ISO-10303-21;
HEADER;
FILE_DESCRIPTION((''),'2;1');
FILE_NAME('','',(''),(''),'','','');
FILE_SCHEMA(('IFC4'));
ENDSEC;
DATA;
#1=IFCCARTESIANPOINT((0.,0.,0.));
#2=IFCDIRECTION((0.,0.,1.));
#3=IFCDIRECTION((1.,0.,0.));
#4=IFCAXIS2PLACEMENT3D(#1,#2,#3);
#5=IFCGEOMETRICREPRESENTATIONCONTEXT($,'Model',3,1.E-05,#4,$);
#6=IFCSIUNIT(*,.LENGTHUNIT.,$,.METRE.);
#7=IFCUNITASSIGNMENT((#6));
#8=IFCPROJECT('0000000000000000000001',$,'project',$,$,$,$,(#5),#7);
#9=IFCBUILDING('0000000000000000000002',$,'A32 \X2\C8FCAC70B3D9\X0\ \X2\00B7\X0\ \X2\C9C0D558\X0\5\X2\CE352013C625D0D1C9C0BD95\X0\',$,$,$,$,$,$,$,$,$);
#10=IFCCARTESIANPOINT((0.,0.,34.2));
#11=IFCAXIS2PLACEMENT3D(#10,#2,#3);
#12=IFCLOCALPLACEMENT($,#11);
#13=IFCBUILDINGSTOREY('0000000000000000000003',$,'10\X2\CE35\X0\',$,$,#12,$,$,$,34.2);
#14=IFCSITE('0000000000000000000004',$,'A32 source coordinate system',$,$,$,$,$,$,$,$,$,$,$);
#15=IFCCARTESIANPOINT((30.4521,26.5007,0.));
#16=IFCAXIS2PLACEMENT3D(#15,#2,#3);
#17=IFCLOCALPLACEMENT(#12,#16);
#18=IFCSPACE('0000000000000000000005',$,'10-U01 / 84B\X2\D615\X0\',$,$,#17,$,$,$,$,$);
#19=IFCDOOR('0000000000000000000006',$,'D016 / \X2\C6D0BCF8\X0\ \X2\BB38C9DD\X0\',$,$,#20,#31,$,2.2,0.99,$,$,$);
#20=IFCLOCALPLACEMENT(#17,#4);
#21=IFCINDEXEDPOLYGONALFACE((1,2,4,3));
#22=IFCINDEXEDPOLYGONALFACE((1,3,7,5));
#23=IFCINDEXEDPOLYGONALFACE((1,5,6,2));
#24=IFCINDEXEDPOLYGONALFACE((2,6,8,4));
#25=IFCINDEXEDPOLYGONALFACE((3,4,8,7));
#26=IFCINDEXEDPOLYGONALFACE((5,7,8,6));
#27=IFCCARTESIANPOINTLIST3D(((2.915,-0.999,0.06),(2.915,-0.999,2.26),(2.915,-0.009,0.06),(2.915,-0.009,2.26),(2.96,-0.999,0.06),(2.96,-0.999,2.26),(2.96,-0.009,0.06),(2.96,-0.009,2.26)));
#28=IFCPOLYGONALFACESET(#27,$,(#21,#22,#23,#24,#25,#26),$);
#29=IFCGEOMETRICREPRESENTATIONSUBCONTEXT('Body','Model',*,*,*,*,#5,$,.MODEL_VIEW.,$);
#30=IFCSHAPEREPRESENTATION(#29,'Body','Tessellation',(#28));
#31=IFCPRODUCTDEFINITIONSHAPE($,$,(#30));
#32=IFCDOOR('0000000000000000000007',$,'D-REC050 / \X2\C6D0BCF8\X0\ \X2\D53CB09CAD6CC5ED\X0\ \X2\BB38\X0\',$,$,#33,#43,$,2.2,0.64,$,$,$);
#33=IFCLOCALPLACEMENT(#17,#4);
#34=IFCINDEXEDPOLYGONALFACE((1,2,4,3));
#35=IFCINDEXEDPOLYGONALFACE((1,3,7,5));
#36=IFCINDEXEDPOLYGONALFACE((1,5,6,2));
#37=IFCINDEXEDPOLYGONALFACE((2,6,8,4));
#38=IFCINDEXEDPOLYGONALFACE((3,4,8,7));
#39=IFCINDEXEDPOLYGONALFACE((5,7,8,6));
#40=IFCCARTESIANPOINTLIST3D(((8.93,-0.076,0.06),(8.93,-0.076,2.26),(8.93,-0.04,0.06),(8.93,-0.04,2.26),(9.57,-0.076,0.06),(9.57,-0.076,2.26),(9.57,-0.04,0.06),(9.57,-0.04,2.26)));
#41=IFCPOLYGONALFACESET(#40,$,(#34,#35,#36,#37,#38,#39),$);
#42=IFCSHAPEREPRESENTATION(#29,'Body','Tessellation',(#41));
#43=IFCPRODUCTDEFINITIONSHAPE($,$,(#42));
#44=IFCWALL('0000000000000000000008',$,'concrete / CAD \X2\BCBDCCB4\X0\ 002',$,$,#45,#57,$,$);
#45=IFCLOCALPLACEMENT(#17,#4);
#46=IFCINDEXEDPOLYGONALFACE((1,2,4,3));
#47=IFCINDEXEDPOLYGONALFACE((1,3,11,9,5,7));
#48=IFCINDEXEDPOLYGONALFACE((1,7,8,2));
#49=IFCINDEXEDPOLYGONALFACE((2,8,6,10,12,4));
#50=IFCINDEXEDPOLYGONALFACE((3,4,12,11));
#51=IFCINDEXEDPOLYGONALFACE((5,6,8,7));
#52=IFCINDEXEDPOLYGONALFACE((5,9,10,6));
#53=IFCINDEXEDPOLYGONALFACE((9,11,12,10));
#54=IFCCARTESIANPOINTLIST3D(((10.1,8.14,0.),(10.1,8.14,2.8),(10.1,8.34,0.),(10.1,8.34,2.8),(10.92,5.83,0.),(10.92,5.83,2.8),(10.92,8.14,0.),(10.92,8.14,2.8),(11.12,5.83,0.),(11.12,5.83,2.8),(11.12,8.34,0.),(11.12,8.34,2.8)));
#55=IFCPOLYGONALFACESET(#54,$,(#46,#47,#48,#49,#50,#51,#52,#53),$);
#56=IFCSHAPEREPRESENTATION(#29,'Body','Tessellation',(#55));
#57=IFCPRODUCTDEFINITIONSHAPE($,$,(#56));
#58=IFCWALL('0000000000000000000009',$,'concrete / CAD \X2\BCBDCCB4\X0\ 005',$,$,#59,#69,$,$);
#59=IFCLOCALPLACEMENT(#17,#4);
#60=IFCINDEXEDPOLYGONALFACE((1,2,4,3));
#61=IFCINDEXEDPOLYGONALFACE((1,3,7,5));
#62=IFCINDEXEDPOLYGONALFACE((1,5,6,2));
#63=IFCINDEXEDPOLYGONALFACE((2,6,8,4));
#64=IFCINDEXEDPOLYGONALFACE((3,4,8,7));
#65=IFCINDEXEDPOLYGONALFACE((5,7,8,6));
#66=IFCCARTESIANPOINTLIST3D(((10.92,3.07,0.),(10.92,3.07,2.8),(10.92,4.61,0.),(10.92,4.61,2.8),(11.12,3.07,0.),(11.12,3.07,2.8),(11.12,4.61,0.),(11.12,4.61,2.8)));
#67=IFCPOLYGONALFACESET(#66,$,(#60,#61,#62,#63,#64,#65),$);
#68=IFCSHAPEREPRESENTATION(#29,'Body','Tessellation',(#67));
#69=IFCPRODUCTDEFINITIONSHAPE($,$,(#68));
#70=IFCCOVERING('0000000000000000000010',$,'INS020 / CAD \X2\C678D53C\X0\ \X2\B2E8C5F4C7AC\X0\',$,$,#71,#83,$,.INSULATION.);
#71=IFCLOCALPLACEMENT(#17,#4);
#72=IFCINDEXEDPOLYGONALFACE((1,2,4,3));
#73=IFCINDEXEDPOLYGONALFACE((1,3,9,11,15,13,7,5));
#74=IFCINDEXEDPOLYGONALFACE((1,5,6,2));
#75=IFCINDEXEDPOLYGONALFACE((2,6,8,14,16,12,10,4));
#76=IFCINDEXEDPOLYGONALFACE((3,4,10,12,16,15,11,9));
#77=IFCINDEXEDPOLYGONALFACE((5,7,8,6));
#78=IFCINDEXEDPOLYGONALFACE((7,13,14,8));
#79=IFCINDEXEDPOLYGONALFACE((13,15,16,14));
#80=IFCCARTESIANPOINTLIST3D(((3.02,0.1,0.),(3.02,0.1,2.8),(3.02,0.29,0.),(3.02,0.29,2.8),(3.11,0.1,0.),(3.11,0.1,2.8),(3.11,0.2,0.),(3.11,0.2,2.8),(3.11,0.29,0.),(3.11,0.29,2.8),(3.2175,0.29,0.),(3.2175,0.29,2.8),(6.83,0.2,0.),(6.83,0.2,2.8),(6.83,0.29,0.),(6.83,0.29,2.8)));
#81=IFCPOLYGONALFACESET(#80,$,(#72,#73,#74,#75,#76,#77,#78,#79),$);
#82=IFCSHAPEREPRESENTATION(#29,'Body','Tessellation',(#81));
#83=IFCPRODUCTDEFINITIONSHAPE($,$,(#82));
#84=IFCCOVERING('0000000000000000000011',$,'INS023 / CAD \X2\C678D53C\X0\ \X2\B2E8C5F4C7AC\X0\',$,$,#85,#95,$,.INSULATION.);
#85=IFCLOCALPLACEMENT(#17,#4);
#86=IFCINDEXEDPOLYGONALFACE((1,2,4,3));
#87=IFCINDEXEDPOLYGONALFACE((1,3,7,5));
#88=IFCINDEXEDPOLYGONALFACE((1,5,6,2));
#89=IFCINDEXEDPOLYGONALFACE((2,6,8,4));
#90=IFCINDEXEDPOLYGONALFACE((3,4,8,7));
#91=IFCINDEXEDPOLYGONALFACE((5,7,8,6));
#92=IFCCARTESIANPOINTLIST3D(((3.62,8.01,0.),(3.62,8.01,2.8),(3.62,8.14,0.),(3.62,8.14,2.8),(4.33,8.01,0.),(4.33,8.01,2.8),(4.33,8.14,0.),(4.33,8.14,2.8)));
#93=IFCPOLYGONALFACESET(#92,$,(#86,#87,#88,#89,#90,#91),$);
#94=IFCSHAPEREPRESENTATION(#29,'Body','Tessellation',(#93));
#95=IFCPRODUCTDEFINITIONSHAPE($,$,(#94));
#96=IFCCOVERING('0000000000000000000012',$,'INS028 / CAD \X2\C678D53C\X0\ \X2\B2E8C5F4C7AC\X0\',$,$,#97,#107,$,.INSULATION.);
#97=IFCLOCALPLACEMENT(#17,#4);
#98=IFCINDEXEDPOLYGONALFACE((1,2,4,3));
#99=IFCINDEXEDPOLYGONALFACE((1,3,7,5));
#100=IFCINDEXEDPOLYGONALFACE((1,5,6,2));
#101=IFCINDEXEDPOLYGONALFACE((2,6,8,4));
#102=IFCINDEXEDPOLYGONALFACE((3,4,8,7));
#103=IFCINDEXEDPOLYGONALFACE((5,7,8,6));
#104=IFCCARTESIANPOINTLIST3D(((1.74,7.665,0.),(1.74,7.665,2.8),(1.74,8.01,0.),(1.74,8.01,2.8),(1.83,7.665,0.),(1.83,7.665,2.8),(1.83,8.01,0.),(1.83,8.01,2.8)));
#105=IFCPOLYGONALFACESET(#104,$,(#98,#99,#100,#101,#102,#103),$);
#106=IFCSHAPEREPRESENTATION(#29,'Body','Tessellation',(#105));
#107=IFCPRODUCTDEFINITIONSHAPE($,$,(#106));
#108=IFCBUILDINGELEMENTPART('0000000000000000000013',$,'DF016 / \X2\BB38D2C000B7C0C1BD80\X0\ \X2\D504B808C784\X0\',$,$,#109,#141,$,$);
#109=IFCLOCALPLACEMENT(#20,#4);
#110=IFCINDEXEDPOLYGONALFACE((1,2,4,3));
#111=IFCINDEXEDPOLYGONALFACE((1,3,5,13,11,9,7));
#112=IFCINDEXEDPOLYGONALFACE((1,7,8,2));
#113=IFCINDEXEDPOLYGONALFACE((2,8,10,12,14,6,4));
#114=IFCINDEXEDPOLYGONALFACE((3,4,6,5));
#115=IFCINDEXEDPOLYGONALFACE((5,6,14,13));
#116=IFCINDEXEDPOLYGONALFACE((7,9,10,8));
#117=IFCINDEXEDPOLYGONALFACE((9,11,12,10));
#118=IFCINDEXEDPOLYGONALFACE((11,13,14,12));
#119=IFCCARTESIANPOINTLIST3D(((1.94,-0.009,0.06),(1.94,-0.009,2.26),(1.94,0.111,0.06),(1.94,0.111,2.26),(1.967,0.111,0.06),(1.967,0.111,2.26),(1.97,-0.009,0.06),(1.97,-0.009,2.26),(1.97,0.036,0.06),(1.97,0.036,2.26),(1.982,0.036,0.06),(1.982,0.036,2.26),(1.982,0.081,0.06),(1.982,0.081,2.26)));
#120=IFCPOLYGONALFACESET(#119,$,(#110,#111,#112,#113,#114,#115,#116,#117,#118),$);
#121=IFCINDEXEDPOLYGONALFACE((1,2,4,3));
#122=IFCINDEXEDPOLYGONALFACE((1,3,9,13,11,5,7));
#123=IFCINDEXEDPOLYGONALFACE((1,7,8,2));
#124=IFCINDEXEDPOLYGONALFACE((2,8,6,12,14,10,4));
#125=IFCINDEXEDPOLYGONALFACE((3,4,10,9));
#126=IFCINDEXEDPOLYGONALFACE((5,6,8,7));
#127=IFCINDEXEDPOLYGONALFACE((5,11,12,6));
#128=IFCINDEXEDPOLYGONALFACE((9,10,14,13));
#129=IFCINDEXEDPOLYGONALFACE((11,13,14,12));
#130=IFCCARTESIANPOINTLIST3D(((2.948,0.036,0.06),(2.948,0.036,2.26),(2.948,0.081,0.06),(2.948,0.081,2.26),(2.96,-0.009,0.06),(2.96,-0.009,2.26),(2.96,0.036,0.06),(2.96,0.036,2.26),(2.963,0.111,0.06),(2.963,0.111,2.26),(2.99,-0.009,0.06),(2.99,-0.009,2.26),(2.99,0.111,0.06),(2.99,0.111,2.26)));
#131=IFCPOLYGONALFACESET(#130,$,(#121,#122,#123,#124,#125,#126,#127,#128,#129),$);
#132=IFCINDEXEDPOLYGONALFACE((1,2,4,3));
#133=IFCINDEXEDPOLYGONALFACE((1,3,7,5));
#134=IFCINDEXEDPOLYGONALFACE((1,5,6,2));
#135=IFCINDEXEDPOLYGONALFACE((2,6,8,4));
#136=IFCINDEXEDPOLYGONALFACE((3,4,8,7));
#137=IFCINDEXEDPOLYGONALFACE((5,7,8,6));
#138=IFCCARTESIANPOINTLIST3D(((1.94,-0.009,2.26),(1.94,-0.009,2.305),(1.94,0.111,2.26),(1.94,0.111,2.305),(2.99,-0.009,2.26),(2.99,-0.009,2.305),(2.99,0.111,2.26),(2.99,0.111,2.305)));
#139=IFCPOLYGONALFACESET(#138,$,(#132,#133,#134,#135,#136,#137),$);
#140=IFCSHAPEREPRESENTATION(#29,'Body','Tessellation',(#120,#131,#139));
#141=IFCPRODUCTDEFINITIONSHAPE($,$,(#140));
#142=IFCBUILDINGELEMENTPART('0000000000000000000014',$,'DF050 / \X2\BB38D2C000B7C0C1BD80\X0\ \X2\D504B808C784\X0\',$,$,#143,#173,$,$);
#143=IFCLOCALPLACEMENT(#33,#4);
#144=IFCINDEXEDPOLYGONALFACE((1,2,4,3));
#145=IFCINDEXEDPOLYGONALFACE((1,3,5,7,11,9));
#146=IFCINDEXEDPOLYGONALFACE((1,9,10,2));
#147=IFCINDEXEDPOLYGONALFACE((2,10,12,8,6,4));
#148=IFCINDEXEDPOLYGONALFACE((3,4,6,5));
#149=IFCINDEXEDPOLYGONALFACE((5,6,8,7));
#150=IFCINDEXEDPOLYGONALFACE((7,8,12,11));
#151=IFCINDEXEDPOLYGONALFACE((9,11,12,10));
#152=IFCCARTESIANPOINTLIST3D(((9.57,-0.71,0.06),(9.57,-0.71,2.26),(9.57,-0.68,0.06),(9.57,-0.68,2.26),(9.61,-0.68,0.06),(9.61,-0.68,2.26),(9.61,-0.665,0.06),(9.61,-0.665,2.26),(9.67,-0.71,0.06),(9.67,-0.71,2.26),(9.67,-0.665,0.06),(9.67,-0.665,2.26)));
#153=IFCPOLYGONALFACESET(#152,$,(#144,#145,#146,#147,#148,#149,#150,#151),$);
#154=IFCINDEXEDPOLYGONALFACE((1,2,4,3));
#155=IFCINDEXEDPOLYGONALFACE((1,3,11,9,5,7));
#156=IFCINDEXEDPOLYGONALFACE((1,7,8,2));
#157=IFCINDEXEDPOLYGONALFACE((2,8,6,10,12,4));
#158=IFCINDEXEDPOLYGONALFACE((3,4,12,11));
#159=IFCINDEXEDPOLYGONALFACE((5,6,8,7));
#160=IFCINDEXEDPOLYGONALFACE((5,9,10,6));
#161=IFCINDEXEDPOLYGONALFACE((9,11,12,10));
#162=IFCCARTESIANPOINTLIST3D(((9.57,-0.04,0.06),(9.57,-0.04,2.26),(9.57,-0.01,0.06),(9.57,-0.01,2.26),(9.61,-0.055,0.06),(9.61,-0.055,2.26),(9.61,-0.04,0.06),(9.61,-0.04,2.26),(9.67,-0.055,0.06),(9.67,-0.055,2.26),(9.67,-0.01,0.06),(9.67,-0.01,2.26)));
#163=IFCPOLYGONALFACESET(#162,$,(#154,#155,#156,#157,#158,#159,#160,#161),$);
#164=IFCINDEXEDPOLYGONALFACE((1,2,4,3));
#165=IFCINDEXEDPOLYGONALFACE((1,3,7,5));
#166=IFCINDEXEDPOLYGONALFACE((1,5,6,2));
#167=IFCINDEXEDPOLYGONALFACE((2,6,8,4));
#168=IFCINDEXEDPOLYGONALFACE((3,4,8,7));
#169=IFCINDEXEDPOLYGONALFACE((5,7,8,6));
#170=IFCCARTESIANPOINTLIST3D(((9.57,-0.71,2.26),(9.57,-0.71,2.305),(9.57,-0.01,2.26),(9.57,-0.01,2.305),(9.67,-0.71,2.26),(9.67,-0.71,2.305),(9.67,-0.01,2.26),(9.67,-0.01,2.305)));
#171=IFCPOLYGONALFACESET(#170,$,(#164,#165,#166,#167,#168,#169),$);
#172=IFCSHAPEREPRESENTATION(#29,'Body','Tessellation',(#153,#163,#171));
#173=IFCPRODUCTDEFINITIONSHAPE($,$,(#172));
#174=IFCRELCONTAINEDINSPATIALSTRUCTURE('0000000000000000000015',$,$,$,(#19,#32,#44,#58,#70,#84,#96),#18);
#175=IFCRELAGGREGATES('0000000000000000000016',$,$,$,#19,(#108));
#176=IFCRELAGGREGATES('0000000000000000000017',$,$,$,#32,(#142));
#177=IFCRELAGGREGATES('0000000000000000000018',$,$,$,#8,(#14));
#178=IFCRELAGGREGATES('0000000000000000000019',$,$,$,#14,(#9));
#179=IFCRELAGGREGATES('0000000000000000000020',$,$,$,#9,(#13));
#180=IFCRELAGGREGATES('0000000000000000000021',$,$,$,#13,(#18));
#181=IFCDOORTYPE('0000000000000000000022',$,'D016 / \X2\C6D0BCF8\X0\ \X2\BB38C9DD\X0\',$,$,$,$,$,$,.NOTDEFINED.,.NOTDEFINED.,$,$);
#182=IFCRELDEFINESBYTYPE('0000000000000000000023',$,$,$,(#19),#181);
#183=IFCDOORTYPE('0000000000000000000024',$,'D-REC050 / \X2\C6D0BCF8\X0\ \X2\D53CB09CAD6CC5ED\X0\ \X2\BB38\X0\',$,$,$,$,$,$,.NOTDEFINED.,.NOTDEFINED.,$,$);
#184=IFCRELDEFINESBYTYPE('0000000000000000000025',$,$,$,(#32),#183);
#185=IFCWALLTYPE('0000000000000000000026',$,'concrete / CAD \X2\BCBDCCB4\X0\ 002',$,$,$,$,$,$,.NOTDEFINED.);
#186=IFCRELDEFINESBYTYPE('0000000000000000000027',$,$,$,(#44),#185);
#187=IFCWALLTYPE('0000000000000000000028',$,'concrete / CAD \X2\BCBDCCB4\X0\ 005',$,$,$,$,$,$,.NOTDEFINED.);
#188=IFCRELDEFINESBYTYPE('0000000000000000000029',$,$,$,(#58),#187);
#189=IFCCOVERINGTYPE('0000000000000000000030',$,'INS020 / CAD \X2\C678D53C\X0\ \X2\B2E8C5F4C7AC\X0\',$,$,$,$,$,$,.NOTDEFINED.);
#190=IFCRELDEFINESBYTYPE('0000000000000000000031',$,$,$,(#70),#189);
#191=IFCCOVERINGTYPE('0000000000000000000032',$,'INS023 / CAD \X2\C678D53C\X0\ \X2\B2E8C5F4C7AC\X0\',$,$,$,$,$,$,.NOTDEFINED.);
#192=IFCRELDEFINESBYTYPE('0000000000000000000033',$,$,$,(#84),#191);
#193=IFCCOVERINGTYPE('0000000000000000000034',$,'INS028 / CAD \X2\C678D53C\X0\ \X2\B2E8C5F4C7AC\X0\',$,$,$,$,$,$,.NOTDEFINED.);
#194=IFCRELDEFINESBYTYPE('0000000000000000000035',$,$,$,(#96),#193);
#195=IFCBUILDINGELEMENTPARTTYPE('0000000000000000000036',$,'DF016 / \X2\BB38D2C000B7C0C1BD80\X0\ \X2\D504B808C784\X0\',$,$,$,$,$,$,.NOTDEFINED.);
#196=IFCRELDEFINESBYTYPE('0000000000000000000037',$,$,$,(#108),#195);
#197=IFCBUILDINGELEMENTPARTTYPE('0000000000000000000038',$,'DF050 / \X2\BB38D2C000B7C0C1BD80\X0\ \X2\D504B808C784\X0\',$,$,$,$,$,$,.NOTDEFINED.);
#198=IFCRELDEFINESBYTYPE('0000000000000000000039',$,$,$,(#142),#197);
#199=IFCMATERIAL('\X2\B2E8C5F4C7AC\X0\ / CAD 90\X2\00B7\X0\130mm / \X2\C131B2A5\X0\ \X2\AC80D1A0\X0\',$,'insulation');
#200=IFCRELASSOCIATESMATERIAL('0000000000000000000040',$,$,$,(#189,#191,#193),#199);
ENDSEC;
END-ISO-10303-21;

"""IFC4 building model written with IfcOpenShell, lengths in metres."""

from ifc_helpers import new_model, si_unit, frame, origin, origin_with_axes, place, context, subcontext, project, spatial, polyline, outline, extrude, source, transform, mapped, material, type_object, type_shapes, element, aggregate, save


model = new_model("IFC4")

# Units and contexts
model_context = context("Model", 3, precision=1e-05, world=origin_with_axes())
body_context = subcontext(model_context, "Body", "Model", "MODEL_VIEW")
ifc_project = project(units=[si_unit("LENGTHUNIT", "METRE")], contexts=[model_context])

# Site, building, storey, space
storey_placement = place(None, frame((0.0, 0.0, 34.2), z_axis=(0.0, 0.0, 1.0), x_axis=(1.0, 0.0, 0.0)))
space_placement = place(storey_placement, frame((30.4521, 26.5007, 0.0), z_axis=(0.0, 0.0, 1.0), x_axis=(1.0, 0.0, 0.0)))
site = spatial("IfcSite", under=ifc_project, Name="A32 source coordinate system")
building = spatial("IfcBuilding", under=site, Name="A32 주거동 · 지하5층–옥탑지붕")
storey = spatial("IfcBuildingStorey", under=building, at=storey_placement, Name="10층", Elevation=34.2)
space = spatial("IfcSpace", under=storey, at=space_placement, Name="10-U01 / 84B형")

# Doors
door_type_1 = type_object("IfcDoorType", Name="D016 / 원본 문짝", OperationType="NOTDEFINED", PredefinedType="NOTDEFINED")
shared_shape_1 = source(origin(), body_context, "Body", "SweptSolid", [
    extrude(outline(polyline([(2.96, -0.009), (2.96, -0.999), (2.915, -0.999), (2.915, -0.009), (2.96, -0.009)])), frame((0.0, 0.0, 0.06)), (0.0, 0.0, 1.0), 2.2),
])
type_shapes(door_type_1, [shared_shape_1])
door_1_placement = place(space_placement, origin_with_axes())
door_1 = element("IfcDoor", 1, at=door_1_placement, inside=space, type_object=door_type_1, Name="D016 / 원본 문짝", OverallHeight=2.2, OverallWidth=0.99, context=body_context, shape_type="MappedRepresentation", body=[
    mapped(shared_shape_1, transform((0.0, 0.0, 0.0), scale=1.0)),
])
door_type_2 = type_object("IfcDoorType", Name="D-REC050 / 원본 피난구역 문", OperationType="NOTDEFINED", PredefinedType="NOTDEFINED")
shared_shape_2 = source(origin(), body_context, "Body", "SweptSolid", [
    extrude(outline(polyline([(9.57, -0.04), (9.57, -0.076), (8.93, -0.076), (8.93, -0.04), (9.57, -0.04)])), frame((0.0, 0.0, 0.06)), (0.0, 0.0, 1.0), 2.2),
])
type_shapes(door_type_2, [shared_shape_2])
door_2_placement = place(space_placement, origin_with_axes())
door_2 = element("IfcDoor", 2, at=door_2_placement, inside=space, type_object=door_type_2, Name="D-REC050 / 원본 피난구역 문", OverallHeight=2.2, OverallWidth=0.64, context=body_context, shape_type="MappedRepresentation", body=[
    mapped(shared_shape_2, transform((0.0, 0.0, 0.0), scale=1.0)),
])

# Walls
wall_type_1 = type_object("IfcWallType", Name="concrete / CAD 벽체 002", PredefinedType="NOTDEFINED")
shared_shape_3 = source(origin(), body_context, "Body", "SweptSolid", [
    extrude(outline(polyline([(11.12, 5.83), (10.92, 5.83), (10.92, 8.14), (10.1, 8.14), (10.1, 8.34), (11.12, 8.34), (11.12, 5.83)])), origin(), (0.0, 0.0, 1.0), 2.8),
])
type_shapes(wall_type_1, [shared_shape_3])
wall_1_placement = place(space_placement, origin_with_axes())
element("IfcWall", 3, at=wall_1_placement, inside=space, type_object=wall_type_1, Name="concrete / CAD 벽체 002", context=body_context, shape_type="MappedRepresentation", body=[
    mapped(shared_shape_3, transform((0.0, 0.0, 0.0), scale=1.0)),
])
wall_type_2 = type_object("IfcWallType", Name="concrete / CAD 벽체 005", PredefinedType="NOTDEFINED")
shared_shape_4 = source(origin(), body_context, "Body", "SweptSolid", [
    extrude(outline(polyline([(11.12, 3.07), (10.92, 3.07), (10.92, 4.61), (11.12, 4.61), (11.12, 3.07)])), origin(), (0.0, 0.0, 1.0), 2.8),
])
type_shapes(wall_type_2, [shared_shape_4])
wall_2_placement = place(space_placement, origin_with_axes())
element("IfcWall", 4, at=wall_2_placement, inside=space, type_object=wall_type_2, Name="concrete / CAD 벽체 005", context=body_context, shape_type="MappedRepresentation", body=[
    mapped(shared_shape_4, transform((0.0, 0.0, 0.0), scale=1.0)),
])

# Coverings
ifc_material = material(Name="단열재 / CAD 90·130mm / 성능 검토", Category="insulation")
covering_type_1 = type_object("IfcCoveringType", Name="INS020 / CAD 외피 단열재", PredefinedType="NOTDEFINED", material=ifc_material)
shared_shape_5 = source(origin(), body_context, "Body", "SweptSolid", [
    extrude(outline(polyline([(3.11, 0.2), (3.11, 0.1), (3.02, 0.1), (3.02, 0.29), (3.11, 0.29), (3.2175, 0.29), (6.83, 0.29), (6.83, 0.2), (3.11, 0.2)])), origin(), (0.0, 0.0, 1.0), 2.8),
])
type_shapes(covering_type_1, [shared_shape_5])
covering_1_placement = place(space_placement, origin_with_axes())
element("IfcCovering", 5, at=covering_1_placement, inside=space, type_object=covering_type_1, Name="INS020 / CAD 외피 단열재", PredefinedType="INSULATION", context=body_context, shape_type="MappedRepresentation", body=[
    mapped(shared_shape_5, transform((0.0, 0.0, 0.0), scale=1.0)),
])
covering_type_2 = type_object("IfcCoveringType", Name="INS023 / CAD 외피 단열재", PredefinedType="NOTDEFINED", material=ifc_material)
shared_shape_6 = source(origin(), body_context, "Body", "SweptSolid", [
    extrude(outline(polyline([(4.33, 8.01), (3.62, 8.01), (3.62, 8.14), (4.33, 8.14), (4.33, 8.01)])), origin(), (0.0, 0.0, 1.0), 2.8),
])
type_shapes(covering_type_2, [shared_shape_6])
covering_2_placement = place(space_placement, origin_with_axes())
element("IfcCovering", 6, at=covering_2_placement, inside=space, type_object=covering_type_2, Name="INS023 / CAD 외피 단열재", PredefinedType="INSULATION", context=body_context, shape_type="MappedRepresentation", body=[
    mapped(shared_shape_6, transform((0.0, 0.0, 0.0), scale=1.0)),
])
covering_type_3 = type_object("IfcCoveringType", Name="INS028 / CAD 외피 단열재", PredefinedType="NOTDEFINED", material=ifc_material)
shared_shape_7 = source(origin(), body_context, "Body", "SweptSolid", [
    extrude(outline(polyline([(1.74, 8.01), (1.83, 8.01), (1.83, 7.665), (1.74, 7.665), (1.74, 8.01)])), origin(), (0.0, 0.0, 1.0), 2.8),
])
type_shapes(covering_type_3, [shared_shape_7])
covering_3_placement = place(space_placement, origin_with_axes())
element("IfcCovering", 7, at=covering_3_placement, inside=space, type_object=covering_type_3, Name="INS028 / CAD 외피 단열재", PredefinedType="INSULATION", context=body_context, shape_type="MappedRepresentation", body=[
    mapped(shared_shape_7, transform((0.0, 0.0, 0.0), scale=1.0)),
])

# Building element parts
building_element_part_type_1 = type_object("IfcBuildingElementPartType", Name="DF016 / 문틀·상부 프레임", PredefinedType="NOTDEFINED")
shared_shape_8 = source(origin(), body_context, "Body", "SweptSolid", [
    extrude(outline(polyline([(1.94, 0.111), (1.967, 0.111), (1.982, 0.081), (1.982, 0.036), (1.97, 0.036), (1.97, -0.009), (1.94, -0.009), (1.94, 0.111)])), frame((0.0, 0.0, 0.06)), (0.0, 0.0, 1.0), 2.2),
    extrude(outline(polyline([(2.96, -0.009), (2.96, 0.036), (2.948, 0.036), (2.948, 0.081), (2.963, 0.111), (2.99, 0.111), (2.99, -0.009), (2.96, -0.009)])), frame((0.0, 0.0, 0.06)), (0.0, 0.0, 1.0), 2.2),
    extrude(outline(polyline([(1.94, -0.009), (1.94, 0.111), (2.99, 0.111), (2.99, -0.009), (1.94, -0.009)])), frame((0.0, 0.0, 2.26)), (0.0, 0.0, 1.0), 0.045),
])
type_shapes(building_element_part_type_1, [shared_shape_8])
building_element_part_1_placement = place(door_1_placement, origin_with_axes())
building_element_part_1 = element("IfcBuildingElementPart", 8, at=building_element_part_1_placement, type_object=building_element_part_type_1, Name="DF016 / 문틀·상부 프레임", context=body_context, shape_type="MappedRepresentation", body=[
    mapped(shared_shape_8, transform((0.0, 0.0, 0.0), scale=1.0)),
])
aggregate(door_1, [building_element_part_1])
building_element_part_type_2 = type_object("IfcBuildingElementPartType", Name="DF050 / 문틀·상부 프레임", PredefinedType="NOTDEFINED")
shared_shape_9 = source(origin(), body_context, "Body", "SweptSolid", [
    extrude(outline(polyline([(9.57, -0.68), (9.61, -0.68), (9.61, -0.665), (9.67, -0.665), (9.67, -0.71), (9.57, -0.71), (9.57, -0.68)])), frame((0.0, 0.0, 0.06)), (0.0, 0.0, 1.0), 2.2),
    extrude(outline(polyline([(9.67, -0.01), (9.67, -0.055), (9.61, -0.055), (9.61, -0.04), (9.57, -0.04), (9.57, -0.01), (9.67, -0.01)])), frame((0.0, 0.0, 0.06)), (0.0, 0.0, 1.0), 2.2),
    extrude(outline(polyline([(9.57, -0.71), (9.57, -0.01), (9.67, -0.01), (9.67, -0.71), (9.57, -0.71)])), frame((0.0, 0.0, 2.26)), (0.0, 0.0, 1.0), 0.045),
])
type_shapes(building_element_part_type_2, [shared_shape_9])
building_element_part_2_placement = place(door_2_placement, origin_with_axes())
building_element_part_2 = element("IfcBuildingElementPart", 9, at=building_element_part_2_placement, type_object=building_element_part_type_2, Name="DF050 / 문틀·상부 프레임", context=body_context, shape_type="MappedRepresentation", body=[
    mapped(shared_shape_9, transform((0.0, 0.0, 0.0), scale=1.0)),
])
aggregate(door_2, [building_element_part_2])

save(model, "model.ifc")
